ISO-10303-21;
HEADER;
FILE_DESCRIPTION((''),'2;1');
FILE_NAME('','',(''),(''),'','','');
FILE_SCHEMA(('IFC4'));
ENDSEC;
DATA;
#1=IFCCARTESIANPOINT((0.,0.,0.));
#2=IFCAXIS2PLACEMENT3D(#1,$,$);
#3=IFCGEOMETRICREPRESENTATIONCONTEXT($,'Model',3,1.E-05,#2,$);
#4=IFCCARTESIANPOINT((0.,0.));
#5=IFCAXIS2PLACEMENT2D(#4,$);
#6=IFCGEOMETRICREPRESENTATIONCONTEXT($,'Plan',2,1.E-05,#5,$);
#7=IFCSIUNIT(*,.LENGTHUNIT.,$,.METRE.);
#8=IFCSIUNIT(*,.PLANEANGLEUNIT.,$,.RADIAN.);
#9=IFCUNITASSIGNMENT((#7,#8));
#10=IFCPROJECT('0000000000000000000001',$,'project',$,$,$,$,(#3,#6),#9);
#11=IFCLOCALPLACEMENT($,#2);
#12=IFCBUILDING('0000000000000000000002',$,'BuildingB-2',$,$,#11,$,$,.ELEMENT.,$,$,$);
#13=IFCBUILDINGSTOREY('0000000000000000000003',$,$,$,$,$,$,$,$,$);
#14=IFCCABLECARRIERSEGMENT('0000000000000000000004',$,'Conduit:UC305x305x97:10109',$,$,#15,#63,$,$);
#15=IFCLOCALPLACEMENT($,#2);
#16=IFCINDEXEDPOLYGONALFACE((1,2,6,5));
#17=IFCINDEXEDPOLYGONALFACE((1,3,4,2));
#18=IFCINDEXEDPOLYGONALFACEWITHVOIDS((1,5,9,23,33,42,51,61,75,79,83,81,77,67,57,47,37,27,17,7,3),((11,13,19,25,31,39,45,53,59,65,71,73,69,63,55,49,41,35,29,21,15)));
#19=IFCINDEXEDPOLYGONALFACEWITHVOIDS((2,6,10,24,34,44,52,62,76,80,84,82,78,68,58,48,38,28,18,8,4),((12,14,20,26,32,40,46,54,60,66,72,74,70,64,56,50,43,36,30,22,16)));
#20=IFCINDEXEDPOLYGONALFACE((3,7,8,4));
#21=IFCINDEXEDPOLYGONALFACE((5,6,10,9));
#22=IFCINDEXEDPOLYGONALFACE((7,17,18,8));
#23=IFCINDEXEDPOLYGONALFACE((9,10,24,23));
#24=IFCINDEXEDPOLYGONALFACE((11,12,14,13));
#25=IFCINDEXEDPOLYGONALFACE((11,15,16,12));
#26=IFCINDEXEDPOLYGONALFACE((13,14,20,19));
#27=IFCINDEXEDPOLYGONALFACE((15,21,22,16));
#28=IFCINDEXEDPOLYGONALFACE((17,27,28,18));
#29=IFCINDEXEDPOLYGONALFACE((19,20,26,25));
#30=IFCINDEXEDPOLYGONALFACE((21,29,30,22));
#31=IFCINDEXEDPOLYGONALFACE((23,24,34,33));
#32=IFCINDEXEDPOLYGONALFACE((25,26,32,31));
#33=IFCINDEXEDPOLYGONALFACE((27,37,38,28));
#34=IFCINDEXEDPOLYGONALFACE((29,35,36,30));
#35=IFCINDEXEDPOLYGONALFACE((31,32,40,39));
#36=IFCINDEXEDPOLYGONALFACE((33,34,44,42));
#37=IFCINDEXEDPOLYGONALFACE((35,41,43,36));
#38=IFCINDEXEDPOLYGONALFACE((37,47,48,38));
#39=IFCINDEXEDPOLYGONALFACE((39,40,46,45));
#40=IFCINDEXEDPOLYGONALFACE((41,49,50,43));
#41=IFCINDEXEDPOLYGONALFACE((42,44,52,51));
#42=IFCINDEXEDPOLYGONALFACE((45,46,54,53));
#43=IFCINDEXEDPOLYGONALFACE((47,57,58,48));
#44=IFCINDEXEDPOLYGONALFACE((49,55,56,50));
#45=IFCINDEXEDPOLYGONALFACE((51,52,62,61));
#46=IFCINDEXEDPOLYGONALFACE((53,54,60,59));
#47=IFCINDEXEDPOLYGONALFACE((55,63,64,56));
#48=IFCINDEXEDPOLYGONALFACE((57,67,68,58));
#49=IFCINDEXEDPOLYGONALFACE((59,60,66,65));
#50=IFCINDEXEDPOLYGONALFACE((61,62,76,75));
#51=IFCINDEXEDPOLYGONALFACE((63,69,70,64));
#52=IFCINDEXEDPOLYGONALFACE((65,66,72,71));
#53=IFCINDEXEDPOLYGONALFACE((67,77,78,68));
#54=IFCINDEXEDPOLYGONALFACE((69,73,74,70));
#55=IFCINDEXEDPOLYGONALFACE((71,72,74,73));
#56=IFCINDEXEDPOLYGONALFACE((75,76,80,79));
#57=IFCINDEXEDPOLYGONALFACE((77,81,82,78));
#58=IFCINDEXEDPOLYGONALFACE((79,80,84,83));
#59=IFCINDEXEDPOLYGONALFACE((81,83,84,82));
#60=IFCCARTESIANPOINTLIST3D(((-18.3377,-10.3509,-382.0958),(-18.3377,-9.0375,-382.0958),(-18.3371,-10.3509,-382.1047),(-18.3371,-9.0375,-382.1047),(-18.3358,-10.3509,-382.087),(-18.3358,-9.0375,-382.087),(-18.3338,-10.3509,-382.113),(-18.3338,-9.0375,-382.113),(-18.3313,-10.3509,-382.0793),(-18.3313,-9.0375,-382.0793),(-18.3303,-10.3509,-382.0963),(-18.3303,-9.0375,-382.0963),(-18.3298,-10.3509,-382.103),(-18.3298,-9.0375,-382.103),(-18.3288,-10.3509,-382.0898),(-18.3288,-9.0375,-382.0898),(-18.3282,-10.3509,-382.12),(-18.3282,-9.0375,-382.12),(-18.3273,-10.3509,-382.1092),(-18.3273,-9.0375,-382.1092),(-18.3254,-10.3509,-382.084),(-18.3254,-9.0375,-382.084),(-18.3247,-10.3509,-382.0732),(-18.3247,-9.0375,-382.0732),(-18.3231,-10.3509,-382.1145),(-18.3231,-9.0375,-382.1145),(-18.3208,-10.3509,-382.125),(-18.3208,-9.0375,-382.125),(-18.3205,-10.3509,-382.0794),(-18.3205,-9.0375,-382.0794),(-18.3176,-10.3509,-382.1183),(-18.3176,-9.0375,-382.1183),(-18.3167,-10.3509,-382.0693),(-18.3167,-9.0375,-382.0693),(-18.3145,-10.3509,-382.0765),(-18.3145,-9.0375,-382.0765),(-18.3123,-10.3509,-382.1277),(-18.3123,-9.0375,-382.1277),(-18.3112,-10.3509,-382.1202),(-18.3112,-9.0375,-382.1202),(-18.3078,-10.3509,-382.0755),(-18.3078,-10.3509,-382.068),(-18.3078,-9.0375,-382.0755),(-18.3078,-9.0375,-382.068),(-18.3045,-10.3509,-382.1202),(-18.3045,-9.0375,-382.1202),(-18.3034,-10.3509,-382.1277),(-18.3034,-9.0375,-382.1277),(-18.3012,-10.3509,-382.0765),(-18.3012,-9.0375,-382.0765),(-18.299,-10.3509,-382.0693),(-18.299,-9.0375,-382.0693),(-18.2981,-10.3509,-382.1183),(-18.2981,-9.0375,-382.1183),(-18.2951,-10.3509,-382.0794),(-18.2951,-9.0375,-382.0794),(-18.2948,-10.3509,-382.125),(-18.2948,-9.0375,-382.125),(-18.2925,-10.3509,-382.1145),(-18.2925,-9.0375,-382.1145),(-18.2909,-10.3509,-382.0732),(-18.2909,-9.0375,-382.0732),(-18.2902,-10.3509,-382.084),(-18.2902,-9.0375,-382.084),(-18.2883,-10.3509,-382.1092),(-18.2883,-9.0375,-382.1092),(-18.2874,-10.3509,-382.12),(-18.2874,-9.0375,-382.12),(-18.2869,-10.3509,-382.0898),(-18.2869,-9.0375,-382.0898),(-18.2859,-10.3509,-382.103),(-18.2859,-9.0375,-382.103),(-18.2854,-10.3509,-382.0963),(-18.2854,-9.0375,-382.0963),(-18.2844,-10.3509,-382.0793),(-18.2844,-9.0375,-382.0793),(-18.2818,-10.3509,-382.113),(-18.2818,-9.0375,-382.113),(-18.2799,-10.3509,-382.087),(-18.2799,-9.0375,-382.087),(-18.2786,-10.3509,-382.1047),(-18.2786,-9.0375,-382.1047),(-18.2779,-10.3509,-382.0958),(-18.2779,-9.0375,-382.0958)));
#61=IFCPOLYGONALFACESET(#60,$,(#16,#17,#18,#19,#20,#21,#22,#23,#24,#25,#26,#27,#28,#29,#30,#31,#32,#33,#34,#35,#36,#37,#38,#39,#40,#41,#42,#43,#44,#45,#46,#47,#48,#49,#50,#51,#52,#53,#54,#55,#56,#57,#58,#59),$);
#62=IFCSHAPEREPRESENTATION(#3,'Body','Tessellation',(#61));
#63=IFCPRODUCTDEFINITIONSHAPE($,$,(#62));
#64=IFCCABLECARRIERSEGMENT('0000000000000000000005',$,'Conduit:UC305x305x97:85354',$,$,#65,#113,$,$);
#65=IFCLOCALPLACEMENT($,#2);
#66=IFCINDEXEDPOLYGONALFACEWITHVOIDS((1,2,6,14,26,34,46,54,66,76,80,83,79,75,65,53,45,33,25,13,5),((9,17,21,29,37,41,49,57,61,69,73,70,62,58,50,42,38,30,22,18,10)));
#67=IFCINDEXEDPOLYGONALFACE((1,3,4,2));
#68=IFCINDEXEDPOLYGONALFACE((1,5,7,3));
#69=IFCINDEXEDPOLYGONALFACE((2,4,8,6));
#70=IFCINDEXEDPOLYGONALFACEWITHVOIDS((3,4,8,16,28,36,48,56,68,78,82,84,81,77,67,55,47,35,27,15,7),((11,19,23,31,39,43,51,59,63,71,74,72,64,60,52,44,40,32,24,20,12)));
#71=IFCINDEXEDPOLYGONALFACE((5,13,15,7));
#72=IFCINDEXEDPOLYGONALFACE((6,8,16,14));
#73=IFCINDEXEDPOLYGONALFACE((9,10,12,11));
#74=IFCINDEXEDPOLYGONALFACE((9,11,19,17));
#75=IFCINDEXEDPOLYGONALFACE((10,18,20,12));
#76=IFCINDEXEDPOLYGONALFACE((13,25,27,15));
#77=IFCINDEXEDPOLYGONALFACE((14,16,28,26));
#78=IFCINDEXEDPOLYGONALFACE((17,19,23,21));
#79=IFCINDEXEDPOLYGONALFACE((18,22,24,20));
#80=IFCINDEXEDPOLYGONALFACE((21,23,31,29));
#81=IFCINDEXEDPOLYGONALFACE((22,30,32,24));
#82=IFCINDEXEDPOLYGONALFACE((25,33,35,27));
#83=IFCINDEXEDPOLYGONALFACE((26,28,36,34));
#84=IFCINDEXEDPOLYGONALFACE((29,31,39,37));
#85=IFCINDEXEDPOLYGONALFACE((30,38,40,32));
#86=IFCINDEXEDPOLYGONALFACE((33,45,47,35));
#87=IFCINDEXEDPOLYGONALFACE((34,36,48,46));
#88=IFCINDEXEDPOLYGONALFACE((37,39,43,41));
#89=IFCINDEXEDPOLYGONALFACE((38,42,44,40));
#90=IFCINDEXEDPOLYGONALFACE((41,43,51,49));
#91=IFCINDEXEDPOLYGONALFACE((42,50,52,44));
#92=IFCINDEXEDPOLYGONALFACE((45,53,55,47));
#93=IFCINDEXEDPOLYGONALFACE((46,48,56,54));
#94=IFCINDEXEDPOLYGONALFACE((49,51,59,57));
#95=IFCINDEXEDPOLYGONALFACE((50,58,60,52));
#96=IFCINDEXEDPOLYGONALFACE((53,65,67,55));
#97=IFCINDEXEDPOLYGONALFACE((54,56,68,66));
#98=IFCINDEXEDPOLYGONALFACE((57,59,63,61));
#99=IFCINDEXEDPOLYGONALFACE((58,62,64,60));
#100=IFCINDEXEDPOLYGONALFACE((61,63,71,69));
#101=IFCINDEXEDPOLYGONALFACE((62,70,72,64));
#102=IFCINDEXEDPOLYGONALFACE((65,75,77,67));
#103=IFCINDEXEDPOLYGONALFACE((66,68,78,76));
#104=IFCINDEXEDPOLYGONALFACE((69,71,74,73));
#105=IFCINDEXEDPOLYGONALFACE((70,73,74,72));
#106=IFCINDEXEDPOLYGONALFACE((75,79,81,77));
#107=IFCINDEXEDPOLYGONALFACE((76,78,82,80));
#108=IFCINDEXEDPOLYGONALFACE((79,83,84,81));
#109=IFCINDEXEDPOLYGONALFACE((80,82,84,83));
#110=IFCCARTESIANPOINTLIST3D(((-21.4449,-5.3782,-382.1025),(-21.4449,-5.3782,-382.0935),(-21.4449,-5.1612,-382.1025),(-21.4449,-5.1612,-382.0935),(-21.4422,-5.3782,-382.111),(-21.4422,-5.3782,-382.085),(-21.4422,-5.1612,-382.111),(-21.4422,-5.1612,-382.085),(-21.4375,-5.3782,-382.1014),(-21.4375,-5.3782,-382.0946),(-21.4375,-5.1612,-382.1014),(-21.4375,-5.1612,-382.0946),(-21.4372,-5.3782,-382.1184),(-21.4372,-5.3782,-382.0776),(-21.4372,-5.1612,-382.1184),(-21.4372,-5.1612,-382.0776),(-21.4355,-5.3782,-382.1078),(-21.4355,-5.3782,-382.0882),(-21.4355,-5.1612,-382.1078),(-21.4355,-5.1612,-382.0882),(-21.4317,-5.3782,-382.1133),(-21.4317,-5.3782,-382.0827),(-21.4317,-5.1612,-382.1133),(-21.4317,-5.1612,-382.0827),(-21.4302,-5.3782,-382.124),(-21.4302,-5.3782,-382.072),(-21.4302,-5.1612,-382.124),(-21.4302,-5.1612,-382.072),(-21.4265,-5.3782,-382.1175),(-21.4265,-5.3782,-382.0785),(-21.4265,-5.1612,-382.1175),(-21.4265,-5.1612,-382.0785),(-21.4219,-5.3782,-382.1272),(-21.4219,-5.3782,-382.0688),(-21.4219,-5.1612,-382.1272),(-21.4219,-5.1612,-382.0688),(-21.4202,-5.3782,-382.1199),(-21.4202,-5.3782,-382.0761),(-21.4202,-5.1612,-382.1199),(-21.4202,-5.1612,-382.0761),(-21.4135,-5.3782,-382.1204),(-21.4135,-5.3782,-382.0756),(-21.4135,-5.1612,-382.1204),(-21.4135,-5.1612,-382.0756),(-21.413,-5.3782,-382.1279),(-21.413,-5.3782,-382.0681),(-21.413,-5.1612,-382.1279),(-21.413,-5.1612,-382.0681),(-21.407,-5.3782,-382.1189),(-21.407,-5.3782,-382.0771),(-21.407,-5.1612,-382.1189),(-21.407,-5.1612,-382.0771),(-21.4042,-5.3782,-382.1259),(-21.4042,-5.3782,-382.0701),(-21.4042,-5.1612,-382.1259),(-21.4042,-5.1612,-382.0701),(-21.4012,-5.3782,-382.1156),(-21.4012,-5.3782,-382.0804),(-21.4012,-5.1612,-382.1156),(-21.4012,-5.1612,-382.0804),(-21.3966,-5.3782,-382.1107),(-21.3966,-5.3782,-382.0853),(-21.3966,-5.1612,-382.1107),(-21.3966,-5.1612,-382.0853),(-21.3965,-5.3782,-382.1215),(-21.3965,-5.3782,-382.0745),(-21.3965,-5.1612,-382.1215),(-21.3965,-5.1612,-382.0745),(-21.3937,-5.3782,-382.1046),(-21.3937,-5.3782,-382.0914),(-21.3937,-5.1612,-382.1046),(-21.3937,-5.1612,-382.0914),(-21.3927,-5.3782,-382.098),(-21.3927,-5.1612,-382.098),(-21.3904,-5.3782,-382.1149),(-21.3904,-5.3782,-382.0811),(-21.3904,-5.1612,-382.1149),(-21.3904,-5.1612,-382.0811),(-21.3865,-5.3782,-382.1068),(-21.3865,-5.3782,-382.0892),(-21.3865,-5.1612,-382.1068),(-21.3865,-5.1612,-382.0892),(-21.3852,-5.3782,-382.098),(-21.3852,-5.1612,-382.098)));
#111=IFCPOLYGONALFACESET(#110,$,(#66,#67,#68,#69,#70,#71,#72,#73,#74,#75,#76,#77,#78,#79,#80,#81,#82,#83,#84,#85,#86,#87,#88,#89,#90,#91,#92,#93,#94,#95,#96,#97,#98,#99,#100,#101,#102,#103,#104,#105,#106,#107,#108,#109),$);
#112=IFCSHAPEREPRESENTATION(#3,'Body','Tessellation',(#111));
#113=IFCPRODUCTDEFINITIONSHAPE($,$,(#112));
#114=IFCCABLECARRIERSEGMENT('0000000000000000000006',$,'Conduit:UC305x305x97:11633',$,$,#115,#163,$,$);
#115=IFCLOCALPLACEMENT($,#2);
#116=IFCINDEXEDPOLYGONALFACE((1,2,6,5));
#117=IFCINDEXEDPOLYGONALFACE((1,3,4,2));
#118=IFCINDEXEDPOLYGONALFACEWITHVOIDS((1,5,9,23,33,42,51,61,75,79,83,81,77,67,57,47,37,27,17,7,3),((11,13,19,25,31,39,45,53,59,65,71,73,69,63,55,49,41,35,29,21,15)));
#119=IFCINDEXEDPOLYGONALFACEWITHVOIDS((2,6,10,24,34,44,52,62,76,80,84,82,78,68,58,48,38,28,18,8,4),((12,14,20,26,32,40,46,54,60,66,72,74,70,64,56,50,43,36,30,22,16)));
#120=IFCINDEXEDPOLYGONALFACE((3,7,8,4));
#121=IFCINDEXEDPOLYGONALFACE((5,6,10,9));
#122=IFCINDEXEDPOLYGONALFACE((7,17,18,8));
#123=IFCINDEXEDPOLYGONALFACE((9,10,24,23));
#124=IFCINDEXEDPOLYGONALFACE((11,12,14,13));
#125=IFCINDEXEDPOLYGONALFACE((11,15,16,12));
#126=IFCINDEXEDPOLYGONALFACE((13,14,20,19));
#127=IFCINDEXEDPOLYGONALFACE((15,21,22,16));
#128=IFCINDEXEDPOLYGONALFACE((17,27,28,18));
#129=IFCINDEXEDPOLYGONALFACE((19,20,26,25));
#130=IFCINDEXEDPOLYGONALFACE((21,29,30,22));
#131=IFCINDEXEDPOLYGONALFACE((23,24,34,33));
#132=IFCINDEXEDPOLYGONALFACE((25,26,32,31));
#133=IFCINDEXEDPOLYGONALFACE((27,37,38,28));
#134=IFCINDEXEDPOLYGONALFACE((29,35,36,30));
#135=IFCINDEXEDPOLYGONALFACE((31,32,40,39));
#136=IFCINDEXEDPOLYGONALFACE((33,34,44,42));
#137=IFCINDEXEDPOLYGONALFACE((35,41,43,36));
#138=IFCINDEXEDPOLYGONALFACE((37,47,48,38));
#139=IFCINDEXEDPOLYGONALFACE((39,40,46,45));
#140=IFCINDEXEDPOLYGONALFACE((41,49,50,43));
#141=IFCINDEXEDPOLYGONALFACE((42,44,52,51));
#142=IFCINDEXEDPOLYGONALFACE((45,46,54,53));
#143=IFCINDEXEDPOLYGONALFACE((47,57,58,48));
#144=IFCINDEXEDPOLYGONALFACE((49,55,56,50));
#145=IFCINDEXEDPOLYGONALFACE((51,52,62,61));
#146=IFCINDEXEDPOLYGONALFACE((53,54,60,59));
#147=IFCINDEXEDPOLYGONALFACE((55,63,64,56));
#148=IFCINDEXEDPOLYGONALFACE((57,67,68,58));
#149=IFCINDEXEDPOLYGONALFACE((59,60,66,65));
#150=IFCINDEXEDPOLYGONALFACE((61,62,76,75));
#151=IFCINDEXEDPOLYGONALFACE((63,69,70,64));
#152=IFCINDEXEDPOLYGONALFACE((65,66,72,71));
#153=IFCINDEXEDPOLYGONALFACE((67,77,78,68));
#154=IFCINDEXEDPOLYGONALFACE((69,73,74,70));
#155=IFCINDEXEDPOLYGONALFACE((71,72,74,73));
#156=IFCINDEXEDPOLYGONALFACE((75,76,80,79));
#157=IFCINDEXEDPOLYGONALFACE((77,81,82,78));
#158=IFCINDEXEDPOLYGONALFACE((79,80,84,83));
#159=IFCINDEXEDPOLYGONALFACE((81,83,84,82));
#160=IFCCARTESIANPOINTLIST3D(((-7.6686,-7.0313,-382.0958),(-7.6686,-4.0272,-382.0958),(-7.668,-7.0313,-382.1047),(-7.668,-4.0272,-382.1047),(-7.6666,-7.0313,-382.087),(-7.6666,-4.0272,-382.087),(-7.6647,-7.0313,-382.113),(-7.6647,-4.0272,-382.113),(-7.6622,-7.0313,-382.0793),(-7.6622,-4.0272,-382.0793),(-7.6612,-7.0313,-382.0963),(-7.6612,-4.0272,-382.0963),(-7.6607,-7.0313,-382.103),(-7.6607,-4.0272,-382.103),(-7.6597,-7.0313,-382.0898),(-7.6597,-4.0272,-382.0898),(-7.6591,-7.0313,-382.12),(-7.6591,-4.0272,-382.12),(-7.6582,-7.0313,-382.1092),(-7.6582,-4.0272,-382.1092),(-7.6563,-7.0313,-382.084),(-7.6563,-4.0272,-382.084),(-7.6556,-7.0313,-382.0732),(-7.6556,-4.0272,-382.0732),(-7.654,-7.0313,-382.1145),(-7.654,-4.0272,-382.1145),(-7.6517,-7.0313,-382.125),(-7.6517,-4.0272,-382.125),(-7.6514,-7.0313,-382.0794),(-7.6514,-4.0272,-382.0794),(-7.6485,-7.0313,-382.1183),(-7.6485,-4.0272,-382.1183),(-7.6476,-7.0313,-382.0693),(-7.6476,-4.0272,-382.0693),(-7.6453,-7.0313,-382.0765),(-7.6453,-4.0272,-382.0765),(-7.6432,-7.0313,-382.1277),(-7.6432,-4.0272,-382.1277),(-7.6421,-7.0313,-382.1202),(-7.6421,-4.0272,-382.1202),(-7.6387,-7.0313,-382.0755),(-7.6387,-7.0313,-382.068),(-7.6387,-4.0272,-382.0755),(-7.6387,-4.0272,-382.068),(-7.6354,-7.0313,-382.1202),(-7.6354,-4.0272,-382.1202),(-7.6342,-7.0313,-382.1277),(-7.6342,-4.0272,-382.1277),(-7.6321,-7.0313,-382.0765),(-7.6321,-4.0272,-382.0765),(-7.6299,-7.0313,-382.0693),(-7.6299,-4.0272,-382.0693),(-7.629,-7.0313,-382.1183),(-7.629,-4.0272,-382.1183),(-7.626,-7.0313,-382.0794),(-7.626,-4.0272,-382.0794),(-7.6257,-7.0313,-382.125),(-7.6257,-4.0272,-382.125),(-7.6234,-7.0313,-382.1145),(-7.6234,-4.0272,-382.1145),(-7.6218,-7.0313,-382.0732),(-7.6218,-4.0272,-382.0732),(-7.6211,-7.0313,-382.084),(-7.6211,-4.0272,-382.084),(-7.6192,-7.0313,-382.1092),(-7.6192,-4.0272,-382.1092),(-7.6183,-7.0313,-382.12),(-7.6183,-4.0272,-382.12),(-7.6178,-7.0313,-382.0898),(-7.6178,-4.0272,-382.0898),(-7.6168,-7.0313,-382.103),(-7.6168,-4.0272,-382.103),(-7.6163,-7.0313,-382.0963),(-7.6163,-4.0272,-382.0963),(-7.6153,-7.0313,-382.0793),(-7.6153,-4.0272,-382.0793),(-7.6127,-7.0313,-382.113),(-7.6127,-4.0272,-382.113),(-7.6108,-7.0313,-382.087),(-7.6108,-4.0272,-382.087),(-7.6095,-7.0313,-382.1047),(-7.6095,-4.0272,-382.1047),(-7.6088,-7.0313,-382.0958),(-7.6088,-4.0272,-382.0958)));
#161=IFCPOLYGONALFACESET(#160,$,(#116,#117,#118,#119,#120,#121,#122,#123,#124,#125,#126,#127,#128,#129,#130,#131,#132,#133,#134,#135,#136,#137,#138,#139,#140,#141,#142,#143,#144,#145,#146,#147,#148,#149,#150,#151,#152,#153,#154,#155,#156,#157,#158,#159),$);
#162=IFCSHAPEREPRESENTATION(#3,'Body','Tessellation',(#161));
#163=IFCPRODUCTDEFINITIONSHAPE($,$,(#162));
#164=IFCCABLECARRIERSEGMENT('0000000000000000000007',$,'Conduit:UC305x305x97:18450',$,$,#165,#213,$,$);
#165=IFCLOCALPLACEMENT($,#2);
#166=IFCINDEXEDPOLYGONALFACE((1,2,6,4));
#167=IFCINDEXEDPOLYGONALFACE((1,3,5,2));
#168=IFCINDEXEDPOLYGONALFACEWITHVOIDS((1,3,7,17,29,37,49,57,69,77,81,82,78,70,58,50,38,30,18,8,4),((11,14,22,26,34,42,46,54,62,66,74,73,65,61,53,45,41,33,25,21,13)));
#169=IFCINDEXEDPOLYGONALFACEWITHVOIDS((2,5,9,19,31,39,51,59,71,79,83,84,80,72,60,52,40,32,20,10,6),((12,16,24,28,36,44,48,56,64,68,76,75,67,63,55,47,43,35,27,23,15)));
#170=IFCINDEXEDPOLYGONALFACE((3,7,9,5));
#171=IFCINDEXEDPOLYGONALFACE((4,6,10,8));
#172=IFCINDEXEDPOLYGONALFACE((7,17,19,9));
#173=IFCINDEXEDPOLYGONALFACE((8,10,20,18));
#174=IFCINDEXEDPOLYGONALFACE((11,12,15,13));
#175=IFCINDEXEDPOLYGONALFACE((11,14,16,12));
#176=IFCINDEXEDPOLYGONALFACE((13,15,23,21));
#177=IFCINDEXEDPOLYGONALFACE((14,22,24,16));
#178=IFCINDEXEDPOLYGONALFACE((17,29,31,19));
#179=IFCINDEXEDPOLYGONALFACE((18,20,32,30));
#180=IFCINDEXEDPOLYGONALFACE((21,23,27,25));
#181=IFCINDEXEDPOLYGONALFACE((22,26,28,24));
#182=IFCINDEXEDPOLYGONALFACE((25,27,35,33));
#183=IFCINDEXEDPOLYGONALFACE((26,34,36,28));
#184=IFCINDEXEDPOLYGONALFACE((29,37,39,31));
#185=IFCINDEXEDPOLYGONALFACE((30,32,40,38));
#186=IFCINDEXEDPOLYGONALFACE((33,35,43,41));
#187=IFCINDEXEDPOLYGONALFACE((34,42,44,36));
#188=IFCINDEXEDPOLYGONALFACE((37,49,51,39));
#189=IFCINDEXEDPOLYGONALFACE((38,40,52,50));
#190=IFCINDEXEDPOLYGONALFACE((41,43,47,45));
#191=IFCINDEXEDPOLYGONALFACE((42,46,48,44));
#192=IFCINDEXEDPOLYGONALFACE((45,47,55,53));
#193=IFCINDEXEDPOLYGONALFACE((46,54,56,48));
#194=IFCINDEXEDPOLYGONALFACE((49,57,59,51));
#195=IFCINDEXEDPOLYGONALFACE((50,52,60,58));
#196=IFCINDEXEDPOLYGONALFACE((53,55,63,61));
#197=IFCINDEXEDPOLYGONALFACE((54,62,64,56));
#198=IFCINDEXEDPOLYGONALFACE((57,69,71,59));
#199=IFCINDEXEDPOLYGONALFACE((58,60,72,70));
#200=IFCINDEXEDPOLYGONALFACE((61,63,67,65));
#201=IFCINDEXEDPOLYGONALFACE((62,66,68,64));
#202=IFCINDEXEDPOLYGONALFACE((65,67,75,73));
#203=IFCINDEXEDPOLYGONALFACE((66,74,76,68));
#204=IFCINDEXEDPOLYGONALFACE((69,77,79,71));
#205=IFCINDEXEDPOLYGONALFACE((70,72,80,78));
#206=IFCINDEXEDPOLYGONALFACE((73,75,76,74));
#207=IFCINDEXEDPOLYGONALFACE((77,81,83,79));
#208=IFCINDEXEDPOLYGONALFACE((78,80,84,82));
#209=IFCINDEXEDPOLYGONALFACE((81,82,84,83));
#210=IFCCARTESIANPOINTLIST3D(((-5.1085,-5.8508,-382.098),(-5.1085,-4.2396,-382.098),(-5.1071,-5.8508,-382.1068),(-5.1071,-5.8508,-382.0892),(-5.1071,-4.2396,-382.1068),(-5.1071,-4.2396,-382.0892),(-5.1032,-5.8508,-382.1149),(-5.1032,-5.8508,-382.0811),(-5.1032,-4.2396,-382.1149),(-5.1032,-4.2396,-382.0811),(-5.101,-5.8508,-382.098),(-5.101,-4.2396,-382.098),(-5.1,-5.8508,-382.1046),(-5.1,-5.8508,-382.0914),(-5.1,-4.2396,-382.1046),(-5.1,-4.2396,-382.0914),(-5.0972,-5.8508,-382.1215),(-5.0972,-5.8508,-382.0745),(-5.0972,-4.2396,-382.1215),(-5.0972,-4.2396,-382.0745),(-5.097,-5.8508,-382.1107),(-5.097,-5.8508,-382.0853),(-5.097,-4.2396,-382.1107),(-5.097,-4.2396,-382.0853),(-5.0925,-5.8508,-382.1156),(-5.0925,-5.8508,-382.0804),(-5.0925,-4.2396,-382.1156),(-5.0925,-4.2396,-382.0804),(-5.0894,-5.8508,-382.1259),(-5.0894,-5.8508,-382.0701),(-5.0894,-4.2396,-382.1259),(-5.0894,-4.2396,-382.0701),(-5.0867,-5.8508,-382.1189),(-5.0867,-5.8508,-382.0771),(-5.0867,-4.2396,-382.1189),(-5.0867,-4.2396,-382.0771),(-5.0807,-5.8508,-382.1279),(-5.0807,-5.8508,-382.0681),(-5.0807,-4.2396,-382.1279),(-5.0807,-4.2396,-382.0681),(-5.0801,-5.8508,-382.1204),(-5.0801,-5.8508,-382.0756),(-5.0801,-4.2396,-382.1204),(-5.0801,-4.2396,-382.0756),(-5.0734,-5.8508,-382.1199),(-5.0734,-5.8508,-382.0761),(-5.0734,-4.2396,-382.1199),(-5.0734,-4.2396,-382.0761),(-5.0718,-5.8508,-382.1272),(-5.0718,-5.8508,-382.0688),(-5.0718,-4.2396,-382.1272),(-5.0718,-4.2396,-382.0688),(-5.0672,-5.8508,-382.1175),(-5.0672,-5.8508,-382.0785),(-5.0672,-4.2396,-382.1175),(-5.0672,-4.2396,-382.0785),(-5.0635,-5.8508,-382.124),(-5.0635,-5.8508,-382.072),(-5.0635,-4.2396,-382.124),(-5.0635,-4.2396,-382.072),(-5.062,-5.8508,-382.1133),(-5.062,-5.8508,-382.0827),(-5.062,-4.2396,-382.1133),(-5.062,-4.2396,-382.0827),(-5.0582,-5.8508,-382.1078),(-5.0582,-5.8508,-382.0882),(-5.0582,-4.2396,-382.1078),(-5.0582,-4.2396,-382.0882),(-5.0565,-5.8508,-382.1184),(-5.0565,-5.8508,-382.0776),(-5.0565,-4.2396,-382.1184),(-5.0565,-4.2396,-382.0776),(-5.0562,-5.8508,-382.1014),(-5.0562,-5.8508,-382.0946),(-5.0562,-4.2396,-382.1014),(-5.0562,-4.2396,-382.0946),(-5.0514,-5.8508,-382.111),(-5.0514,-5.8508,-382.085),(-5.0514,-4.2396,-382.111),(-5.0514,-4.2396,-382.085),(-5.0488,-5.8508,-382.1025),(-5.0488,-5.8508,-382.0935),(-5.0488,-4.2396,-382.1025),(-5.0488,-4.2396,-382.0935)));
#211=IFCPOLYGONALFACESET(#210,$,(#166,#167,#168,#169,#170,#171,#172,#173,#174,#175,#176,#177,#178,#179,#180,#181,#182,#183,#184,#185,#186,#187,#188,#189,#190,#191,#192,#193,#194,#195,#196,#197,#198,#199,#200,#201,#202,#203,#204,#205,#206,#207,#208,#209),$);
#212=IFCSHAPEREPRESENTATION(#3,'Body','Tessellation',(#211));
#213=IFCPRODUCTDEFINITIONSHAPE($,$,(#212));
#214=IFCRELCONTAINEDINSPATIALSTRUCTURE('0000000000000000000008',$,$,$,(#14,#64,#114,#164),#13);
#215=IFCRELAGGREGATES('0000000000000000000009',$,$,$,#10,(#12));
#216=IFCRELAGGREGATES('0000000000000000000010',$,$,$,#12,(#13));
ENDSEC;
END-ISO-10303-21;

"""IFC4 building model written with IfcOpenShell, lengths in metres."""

from ifc_helpers import new_model, entity, si_unit, origin, origin_2d, place, context, project, spatial, element, save


model = new_model("IFC4")

# Units and contexts
model_context = context("Model", 3, precision=1e-05, world=origin())
plan_context = context("Plan", 2, precision=1e-05, world=origin_2d())
ifc_project = project(units=[si_unit("LENGTHUNIT", "METRE"), si_unit("PLANEANGLEUNIT", "RADIAN")], contexts=[model_context, plan_context])

# Building, storey
building_placement = place(None, origin())
building = spatial("IfcBuilding", under=ifc_project, at=building_placement, Name="BuildingB-2", CompositionType="ELEMENT")
storey = spatial("IfcBuildingStorey", under=building)

# Cable carrier segments
element("IfcCableCarrierSegment", 1, inside=storey, Name="Conduit:UC305x305x97:10109", context=model_context, shape_type="AdvancedSweptSolid", body=[
    entity("IfcSweptDiskSolid", entity("IfcCompositeCurve", [entity("IfcCompositeCurveSegment", "CONTINUOUS", False, entity("IfcPolyline", [entity("IfcCartesianPoint", [18.3078, 9.0375, 382.098]), entity("IfcCartesianPoint", [18.3078, 10.3509, 382.098])]))], False), 0.03, 0.0225),
])
element("IfcCableCarrierSegment", 2, inside=storey, Name="Conduit:UC305x305x97:85354", context=model_context, shape_type="AdvancedSweptSolid", body=[
    entity("IfcSweptDiskSolid", entity("IfcCompositeCurve", [entity("IfcCompositeCurveSegment", "CONTINUOUS", False, entity("IfcPolyline", [entity("IfcCartesianPoint", [21.4152, 5.1612, 382.098]), entity("IfcCartesianPoint", [21.4152, 5.3782, 382.098])]))], False), 0.03, 0.0225),
])
element("IfcCableCarrierSegment", 3, inside=storey, Name="Conduit:UC305x305x97:11633", context=model_context, shape_type="AdvancedSweptSolid", body=[
    entity("IfcSweptDiskSolid", entity("IfcCompositeCurve", [entity("IfcCompositeCurveSegment", "CONTINUOUS", False, entity("IfcPolyline", [entity("IfcCartesianPoint", [7.6387, 4.0272, 382.098]), entity("IfcCartesianPoint", [7.6387, 7.0313, 382.098])]))], False), 0.03, 0.0225),
])
element("IfcCableCarrierSegment", 4, inside=storey, Name="Conduit:UC305x305x97:18450", context=model_context, shape_type="AdvancedSweptSolid", body=[
    entity("IfcSweptDiskSolid", entity("IfcCompositeCurve", [entity("IfcCompositeCurveSegment", "CONTINUOUS", False, entity("IfcPolyline", [entity("IfcCartesianPoint", [5.0785, 5.8508, 382.098]), entity("IfcCartesianPoint", [5.0785, 4.2396, 382.098])]))], False), 0.03, 0.0225),
])

save(model, "model.ifc")
